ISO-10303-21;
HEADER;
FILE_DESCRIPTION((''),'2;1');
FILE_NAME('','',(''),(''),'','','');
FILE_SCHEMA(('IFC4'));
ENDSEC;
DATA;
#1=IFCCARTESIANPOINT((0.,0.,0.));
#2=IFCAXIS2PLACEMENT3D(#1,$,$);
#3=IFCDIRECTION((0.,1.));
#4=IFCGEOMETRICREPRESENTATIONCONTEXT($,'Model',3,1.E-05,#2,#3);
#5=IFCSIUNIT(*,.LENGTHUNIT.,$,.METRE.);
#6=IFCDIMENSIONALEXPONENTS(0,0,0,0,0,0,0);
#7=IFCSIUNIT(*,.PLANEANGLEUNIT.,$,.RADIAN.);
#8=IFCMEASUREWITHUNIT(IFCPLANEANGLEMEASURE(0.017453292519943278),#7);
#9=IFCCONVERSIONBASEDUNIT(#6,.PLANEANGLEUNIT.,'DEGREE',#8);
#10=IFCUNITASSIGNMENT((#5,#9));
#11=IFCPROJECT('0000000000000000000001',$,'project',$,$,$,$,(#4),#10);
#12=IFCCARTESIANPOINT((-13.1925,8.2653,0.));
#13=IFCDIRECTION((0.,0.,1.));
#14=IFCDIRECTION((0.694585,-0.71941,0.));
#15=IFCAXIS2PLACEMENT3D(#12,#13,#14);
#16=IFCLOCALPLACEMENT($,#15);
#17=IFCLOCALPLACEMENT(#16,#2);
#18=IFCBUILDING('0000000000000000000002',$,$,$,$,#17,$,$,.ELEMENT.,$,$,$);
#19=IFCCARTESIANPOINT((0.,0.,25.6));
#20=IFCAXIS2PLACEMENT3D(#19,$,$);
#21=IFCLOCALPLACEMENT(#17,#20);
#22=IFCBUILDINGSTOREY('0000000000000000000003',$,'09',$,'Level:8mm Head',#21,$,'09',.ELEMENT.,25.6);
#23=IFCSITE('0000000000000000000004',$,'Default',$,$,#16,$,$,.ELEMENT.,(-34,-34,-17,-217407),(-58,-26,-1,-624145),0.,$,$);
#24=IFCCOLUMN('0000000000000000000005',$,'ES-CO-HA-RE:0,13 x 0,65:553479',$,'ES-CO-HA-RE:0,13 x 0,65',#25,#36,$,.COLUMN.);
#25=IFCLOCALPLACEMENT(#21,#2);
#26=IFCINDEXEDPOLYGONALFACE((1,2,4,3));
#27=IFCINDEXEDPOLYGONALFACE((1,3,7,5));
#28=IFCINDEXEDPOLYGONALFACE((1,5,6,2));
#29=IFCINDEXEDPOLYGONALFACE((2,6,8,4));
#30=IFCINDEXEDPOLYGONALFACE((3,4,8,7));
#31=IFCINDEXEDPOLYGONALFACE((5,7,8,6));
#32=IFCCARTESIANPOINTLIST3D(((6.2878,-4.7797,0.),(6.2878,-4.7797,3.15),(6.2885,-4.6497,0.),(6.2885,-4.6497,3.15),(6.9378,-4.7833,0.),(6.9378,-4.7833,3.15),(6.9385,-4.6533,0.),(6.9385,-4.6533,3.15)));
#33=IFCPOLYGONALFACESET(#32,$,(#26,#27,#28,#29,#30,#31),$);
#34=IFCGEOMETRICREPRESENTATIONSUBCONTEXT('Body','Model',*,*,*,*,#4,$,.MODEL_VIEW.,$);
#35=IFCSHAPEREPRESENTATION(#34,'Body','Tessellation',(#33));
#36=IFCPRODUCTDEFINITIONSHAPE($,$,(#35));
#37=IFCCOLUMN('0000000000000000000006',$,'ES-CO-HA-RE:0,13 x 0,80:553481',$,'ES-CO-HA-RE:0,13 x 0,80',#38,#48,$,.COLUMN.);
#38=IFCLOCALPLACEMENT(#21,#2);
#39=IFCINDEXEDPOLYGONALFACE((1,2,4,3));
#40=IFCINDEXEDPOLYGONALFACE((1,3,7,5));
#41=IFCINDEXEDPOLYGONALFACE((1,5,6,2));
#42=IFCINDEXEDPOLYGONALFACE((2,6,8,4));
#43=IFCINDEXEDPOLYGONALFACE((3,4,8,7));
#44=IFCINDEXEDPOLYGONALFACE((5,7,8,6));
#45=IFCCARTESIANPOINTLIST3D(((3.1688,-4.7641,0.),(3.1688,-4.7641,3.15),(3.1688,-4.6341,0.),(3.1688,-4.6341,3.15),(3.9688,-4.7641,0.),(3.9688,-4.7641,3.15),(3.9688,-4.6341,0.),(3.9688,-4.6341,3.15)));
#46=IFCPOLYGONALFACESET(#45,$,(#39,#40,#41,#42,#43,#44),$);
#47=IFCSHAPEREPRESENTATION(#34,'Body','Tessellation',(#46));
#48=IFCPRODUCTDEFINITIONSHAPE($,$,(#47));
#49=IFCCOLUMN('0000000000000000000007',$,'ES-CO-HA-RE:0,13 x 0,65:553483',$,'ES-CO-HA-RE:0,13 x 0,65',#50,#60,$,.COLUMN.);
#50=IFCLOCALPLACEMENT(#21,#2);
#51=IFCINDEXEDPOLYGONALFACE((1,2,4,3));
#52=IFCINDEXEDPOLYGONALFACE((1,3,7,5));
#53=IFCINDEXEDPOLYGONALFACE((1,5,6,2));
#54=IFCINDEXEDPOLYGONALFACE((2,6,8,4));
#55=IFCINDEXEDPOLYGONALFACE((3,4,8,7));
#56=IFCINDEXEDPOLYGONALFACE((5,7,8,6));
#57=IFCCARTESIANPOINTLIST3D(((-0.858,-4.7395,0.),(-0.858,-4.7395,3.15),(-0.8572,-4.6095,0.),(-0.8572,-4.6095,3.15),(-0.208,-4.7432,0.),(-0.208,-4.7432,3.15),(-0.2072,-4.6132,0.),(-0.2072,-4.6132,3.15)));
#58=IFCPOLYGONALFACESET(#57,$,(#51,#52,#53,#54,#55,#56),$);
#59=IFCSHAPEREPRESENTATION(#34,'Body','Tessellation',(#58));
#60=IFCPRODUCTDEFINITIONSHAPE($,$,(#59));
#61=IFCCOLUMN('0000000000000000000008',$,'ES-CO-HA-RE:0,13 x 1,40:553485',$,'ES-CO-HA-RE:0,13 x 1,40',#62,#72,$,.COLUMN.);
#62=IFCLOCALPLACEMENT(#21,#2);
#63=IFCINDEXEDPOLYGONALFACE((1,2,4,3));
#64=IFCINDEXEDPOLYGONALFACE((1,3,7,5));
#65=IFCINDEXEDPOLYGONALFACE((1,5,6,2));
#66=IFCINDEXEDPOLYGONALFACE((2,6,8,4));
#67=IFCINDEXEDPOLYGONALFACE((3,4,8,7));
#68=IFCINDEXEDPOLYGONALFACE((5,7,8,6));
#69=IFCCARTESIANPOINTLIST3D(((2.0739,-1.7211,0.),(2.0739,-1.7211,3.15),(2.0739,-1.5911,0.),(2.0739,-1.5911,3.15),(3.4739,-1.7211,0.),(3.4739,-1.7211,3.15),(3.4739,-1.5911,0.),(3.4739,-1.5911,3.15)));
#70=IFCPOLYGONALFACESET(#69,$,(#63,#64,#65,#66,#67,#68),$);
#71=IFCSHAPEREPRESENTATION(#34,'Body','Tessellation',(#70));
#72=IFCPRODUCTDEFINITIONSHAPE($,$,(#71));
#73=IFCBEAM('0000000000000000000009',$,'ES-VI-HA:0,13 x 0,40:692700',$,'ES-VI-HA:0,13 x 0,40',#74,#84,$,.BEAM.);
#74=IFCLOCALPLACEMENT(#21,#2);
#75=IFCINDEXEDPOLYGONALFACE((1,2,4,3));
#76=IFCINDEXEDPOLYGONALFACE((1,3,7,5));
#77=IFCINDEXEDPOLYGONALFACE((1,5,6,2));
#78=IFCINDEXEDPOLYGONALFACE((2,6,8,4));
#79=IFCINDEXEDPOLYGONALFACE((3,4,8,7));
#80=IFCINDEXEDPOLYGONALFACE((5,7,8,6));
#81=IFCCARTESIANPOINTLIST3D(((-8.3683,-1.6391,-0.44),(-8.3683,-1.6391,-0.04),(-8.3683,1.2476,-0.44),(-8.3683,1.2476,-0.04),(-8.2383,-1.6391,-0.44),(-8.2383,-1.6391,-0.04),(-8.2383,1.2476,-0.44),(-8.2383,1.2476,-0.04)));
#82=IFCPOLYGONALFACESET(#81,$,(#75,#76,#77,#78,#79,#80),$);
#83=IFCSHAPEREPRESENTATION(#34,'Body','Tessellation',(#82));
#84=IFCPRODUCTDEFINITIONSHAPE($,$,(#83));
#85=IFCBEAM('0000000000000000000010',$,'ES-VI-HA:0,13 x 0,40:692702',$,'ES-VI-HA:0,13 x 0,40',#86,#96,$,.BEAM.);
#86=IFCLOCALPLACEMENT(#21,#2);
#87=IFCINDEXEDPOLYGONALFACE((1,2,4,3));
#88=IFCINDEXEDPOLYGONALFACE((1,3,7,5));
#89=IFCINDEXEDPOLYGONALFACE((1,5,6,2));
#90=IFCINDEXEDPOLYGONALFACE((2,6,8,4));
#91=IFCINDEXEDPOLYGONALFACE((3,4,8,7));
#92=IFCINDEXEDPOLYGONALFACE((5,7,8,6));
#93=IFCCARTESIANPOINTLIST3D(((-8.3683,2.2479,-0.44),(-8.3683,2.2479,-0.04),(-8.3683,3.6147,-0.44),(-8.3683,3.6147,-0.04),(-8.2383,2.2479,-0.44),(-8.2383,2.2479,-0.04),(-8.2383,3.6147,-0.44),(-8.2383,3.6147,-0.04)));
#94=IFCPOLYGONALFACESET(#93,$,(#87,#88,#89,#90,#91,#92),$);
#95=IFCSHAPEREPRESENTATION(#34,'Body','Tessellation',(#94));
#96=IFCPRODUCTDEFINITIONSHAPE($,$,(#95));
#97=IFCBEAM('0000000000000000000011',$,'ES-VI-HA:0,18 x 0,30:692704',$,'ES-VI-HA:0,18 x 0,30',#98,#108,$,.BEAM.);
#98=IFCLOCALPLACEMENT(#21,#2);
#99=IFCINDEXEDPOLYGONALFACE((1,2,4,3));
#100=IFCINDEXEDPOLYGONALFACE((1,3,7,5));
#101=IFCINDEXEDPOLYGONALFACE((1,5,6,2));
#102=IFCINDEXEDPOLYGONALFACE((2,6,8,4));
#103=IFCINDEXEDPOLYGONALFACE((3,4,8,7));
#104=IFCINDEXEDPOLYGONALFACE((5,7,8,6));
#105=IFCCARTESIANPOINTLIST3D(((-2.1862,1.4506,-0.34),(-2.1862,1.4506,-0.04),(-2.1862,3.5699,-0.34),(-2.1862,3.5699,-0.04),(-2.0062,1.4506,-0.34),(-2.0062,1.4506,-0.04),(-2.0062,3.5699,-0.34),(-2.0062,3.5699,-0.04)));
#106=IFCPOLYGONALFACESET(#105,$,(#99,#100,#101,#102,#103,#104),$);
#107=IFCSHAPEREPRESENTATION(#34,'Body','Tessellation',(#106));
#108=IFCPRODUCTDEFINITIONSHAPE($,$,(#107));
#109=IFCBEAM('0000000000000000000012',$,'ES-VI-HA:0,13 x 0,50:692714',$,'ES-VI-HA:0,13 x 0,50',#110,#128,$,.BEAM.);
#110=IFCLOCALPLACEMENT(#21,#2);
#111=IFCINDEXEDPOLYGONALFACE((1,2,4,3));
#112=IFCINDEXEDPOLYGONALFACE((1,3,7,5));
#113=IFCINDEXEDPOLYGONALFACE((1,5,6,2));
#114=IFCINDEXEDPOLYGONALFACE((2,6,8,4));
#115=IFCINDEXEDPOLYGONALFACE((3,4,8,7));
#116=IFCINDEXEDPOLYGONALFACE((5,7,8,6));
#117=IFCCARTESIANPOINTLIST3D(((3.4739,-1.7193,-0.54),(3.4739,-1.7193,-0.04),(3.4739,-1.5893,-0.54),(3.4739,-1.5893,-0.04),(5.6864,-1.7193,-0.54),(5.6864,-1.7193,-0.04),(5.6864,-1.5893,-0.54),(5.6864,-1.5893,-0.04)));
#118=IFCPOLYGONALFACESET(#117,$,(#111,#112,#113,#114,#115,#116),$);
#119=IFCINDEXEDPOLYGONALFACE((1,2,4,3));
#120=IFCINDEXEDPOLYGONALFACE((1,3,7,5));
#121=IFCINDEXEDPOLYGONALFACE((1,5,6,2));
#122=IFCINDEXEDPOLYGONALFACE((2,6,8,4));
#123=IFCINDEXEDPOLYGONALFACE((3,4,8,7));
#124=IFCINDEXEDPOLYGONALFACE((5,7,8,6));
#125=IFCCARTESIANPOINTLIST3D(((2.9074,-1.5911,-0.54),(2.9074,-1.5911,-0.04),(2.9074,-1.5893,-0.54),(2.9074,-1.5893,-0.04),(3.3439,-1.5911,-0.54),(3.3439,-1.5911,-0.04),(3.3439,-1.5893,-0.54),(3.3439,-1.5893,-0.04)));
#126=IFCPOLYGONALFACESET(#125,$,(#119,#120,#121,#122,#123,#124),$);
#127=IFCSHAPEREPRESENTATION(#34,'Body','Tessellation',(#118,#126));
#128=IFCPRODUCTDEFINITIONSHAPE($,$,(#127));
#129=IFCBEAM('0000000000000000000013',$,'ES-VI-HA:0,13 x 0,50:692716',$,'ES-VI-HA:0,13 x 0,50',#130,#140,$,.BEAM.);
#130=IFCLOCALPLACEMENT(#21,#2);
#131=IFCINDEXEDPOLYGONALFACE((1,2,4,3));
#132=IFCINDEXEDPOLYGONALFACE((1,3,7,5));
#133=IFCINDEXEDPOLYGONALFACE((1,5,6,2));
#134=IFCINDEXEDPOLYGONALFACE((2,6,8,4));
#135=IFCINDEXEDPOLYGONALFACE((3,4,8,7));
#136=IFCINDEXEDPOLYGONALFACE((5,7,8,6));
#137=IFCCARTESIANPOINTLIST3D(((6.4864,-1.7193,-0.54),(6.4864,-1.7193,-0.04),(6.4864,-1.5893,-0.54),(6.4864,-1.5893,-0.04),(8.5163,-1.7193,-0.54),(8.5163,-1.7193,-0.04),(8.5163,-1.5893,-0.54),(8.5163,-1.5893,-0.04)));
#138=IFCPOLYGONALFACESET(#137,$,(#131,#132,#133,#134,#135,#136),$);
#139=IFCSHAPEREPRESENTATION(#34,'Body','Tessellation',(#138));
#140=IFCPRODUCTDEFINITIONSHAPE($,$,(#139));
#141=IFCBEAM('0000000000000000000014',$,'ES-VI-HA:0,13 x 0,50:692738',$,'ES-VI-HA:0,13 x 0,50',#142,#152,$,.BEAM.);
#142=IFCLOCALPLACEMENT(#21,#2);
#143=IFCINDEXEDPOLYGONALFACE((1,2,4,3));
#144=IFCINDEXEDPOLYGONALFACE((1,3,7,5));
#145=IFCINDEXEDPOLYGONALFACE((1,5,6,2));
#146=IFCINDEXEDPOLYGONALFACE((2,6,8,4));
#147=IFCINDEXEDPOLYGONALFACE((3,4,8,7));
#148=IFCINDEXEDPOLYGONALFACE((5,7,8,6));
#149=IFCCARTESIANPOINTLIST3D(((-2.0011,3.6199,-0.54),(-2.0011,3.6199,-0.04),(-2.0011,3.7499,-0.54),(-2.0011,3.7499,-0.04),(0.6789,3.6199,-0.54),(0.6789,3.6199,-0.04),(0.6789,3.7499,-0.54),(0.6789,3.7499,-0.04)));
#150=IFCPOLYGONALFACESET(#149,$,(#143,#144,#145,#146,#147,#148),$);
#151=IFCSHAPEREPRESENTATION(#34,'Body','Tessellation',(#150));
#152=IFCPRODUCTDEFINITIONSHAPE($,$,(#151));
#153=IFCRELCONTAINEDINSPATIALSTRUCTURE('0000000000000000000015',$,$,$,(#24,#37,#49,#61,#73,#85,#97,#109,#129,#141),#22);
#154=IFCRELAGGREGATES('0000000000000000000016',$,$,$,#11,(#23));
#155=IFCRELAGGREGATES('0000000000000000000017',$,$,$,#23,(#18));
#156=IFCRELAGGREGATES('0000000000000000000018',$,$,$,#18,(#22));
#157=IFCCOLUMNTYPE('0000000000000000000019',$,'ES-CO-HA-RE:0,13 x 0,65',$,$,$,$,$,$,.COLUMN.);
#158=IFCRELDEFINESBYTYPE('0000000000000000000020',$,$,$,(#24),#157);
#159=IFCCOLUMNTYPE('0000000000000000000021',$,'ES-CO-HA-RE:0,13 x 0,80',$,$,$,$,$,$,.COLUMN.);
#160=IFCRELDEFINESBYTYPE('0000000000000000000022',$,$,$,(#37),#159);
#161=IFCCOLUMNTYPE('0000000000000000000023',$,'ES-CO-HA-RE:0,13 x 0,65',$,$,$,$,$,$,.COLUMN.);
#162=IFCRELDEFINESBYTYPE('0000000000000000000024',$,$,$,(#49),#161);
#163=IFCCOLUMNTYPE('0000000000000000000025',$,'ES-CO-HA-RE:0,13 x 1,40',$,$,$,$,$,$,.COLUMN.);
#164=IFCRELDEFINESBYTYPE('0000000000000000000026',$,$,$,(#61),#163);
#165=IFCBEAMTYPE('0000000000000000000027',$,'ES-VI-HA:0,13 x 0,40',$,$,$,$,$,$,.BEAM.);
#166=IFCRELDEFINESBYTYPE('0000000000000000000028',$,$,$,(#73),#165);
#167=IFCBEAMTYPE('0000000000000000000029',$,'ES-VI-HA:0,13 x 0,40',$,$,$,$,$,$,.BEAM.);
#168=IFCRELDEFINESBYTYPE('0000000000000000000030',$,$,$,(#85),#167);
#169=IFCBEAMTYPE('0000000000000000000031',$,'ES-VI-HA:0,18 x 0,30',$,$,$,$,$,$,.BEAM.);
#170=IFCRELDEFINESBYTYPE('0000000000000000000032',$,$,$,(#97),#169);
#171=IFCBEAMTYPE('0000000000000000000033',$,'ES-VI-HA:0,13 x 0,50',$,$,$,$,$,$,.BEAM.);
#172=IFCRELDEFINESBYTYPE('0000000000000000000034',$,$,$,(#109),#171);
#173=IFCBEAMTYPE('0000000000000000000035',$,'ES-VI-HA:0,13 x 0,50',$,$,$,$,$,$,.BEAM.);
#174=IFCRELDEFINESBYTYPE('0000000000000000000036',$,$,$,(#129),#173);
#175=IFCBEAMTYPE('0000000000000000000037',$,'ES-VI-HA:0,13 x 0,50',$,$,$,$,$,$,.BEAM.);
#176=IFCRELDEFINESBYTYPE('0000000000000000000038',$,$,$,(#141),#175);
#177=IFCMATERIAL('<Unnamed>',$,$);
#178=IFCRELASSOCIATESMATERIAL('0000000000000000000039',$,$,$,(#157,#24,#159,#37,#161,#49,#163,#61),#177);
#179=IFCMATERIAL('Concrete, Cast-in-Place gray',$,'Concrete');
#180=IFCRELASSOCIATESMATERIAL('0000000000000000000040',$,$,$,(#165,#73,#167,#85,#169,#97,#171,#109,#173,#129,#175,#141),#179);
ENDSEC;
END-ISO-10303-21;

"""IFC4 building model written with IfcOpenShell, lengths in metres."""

from ifc_helpers import new_model, entity, si_unit, converted_unit, direction, frame, origin, place, context, subcontext, project, spatial, indexed_curve, outline, extrude, source, transform, mapped, material, type_object, type_shapes, element, save


model = new_model("IFC4")

# Units and contexts
model_context = context("Model", 3, precision=1e-05, world=origin(), true_north=direction((0.0, 1.0)))
body_context = subcontext(model_context, "Body", "Model", "MODEL_VIEW")
ifc_project = project(units=[si_unit("LENGTHUNIT", "METRE"), converted_unit("PLANEANGLEUNIT", "DEGREE", entity("IfcPlaneAngleMeasure", 0.017453292519943278), si_unit("PLANEANGLEUNIT", "RADIAN"), dimensions=[0, 0, 0, 0, 0, 0, 0])], contexts=[model_context])

# Site, building, storey
site_placement = place(None, frame((-13.1925, 8.2653, 0.0), z_axis=(0.0, 0.0, 1.0), x_axis=(0.694585, -0.71941, 0.0)))
site = spatial("IfcSite", under=ifc_project, at=site_placement, Name="Default", CompositionType="ELEMENT", RefLatitude=(-34, -34, -17, -217407), RefLongitude=(-58, -26, -1, -624145), RefElevation=0.0)
building_placement = place(site_placement, origin())
building = spatial("IfcBuilding", under=site, at=building_placement, CompositionType="ELEMENT")
storey_placement = place(building_placement, frame((0.0, 0.0, 25.6)))
storey = spatial("IfcBuildingStorey", under=building, at=storey_placement, Name="09", ObjectType="Level:8mm Head", LongName="09", CompositionType="ELEMENT", Elevation=25.6)

# Columns
ifc_material_1 = material(Name="<Unnamed>")
column_type_1 = type_object("IfcColumnType", Name="ES-CO-HA-RE:0,13 x 0,65", PredefinedType="COLUMN", material=ifc_material_1)
shared_shape_1 = source(origin(), body_context, "Body", "SweptSolid", [
    extrude(outline(indexed_curve([(-0.325, -0.065), (0.325, -0.065), (0.325, 0.065), (-0.325, 0.065), (-0.325, -0.065)], self_intersect=False)), frame((6.6131, -4.7165, 25.6), z_axis=(0.0, 0.0, 1.0), x_axis=(-0.999984, 0.005619, 0.0)), (0.0, 0.0, 1.0), 3.15),
])
type_shapes(column_type_1, [shared_shape_1])
column_1_placement = place(storey_placement, frame((0.0, 0.0, -25.6)))
element("IfcColumn", 1, at=column_1_placement, inside=storey, type_object=column_type_1, material=ifc_material_1, Name="ES-CO-HA-RE:0,13 x 0,65:553479", ObjectType="ES-CO-HA-RE:0,13 x 0,65", PredefinedType="COLUMN", context=body_context, shape_type="MappedRepresentation", body=[
    mapped(shared_shape_1, transform((0.0, 0.0, 0.0), scale=1.0)),
])
column_type_2 = type_object("IfcColumnType", Name="ES-CO-HA-RE:0,13 x 0,80", PredefinedType="COLUMN", material=ifc_material_1)
shared_shape_2 = source(origin(), body_context, "Body", "SweptSolid", [
    extrude(outline(indexed_curve([(-0.4, -0.065), (0.4, -0.065), (0.4, 0.065), (-0.4, 0.065), (-0.4, -0.065)], self_intersect=False)), frame((3.5688, -4.6991, 25.6), z_axis=(0.0, 0.0, 1.0), x_axis=(-1.0, 0.0, 0.0)), (0.0, 0.0, 1.0), 3.15),
])
type_shapes(column_type_2, [shared_shape_2])
column_2_placement = place(storey_placement, frame((0.0, 0.0, -25.6)))
element("IfcColumn", 2, at=column_2_placement, inside=storey, type_object=column_type_2, material=ifc_material_1, Name="ES-CO-HA-RE:0,13 x 0,80:553481", ObjectType="ES-CO-HA-RE:0,13 x 0,80", PredefinedType="COLUMN", context=body_context, shape_type="MappedRepresentation", body=[
    mapped(shared_shape_2, transform((0.0, 0.0, 0.0), scale=1.0)),
])
column_type_3 = type_object("IfcColumnType", Name="ES-CO-HA-RE:0,13 x 0,65", PredefinedType="COLUMN", material=ifc_material_1)
shared_shape_3 = source(origin(), body_context, "Body", "SweptSolid", [
    extrude(outline(indexed_curve([(-0.325, -0.065), (0.325, -0.065), (0.325, 0.065), (-0.325, 0.065), (-0.325, -0.065)], self_intersect=False)), frame((-0.5326, -4.6764, 25.6), z_axis=(0.0, 0.0, 1.0), x_axis=(-0.999984, 0.005619, 0.0)), (0.0, 0.0, 1.0), 3.15),
])
type_shapes(column_type_3, [shared_shape_3])
column_3_placement = place(storey_placement, frame((0.0, 0.0, -25.6)))
element("IfcColumn", 3, at=column_3_placement, inside=storey, type_object=column_type_3, material=ifc_material_1, Name="ES-CO-HA-RE:0,13 x 0,65:553483", ObjectType="ES-CO-HA-RE:0,13 x 0,65", PredefinedType="COLUMN", context=body_context, shape_type="MappedRepresentation", body=[
    mapped(shared_shape_3, transform((0.0, 0.0, 0.0), scale=1.0)),
])
column_type_4 = type_object("IfcColumnType", Name="ES-CO-HA-RE:0,13 x 1,40", PredefinedType="COLUMN", material=ifc_material_1)
shared_shape_4 = source(origin(), body_context, "Body", "SweptSolid", [
    extrude(outline(indexed_curve([(-0.7, -0.065), (0.7, -0.065), (0.7, 0.065), (-0.7, 0.065), (-0.7, -0.065)], self_intersect=False)), frame((2.7739, -1.6561, 25.6), z_axis=(0.0, 0.0, 1.0), x_axis=(-1.0, 0.0, 0.0)), (0.0, 0.0, 1.0), 3.15),
])
type_shapes(column_type_4, [shared_shape_4])
column_4_placement = place(storey_placement, frame((0.0, 0.0, -25.6)))
element("IfcColumn", 4, at=column_4_placement, inside=storey, type_object=column_type_4, material=ifc_material_1, Name="ES-CO-HA-RE:0,13 x 1,40:553485", ObjectType="ES-CO-HA-RE:0,13 x 1,40", PredefinedType="COLUMN", context=body_context, shape_type="MappedRepresentation", body=[
    mapped(shared_shape_4, transform((0.0, 0.0, 0.0), scale=1.0)),
])

# Beams
ifc_material_2 = material(Name="Concrete, Cast-in-Place gray", Category="Concrete")
beam_type_1 = type_object("IfcBeamType", Name="ES-VI-HA:0,13 x 0,40", PredefinedType="BEAM", material=ifc_material_2)
shared_shape_5 = source(origin(), body_context, "Body", "SweptSolid", [
    extrude(outline(indexed_curve([(-0.065, -0.2), (0.065, -0.2), (0.065, 0.2), (-0.065, 0.2), (-0.065, -0.2)], self_intersect=False)), frame((-8.3033, -1.6391, 25.36), z_axis=(0.0, 1.0, 0.0), x_axis=(-1.0, 0.0, 0.0)), (0.0, 0.0, 1.0), 2.8867),
])
type_shapes(beam_type_1, [shared_shape_5])
beam_1_placement = place(storey_placement, frame((0.0, 0.0, -25.6)))
element("IfcBeam", 5, at=beam_1_placement, inside=storey, type_object=beam_type_1, material=ifc_material_2, Name="ES-VI-HA:0,13 x 0,40:692700", ObjectType="ES-VI-HA:0,13 x 0,40", PredefinedType="BEAM", context=body_context, shape_type="MappedRepresentation", body=[
    mapped(shared_shape_5, transform((0.0, 0.0, 0.0), scale=1.0)),
])
beam_type_2 = type_object("IfcBeamType", Name="ES-VI-HA:0,13 x 0,40", PredefinedType="BEAM", material=ifc_material_2)
shared_shape_6 = source(origin(), body_context, "Body", "SweptSolid", [
    extrude(outline(indexed_curve([(-0.065, -0.2), (0.065, -0.2), (0.065, 0.2), (-0.065, 0.2), (-0.065, -0.2)], self_intersect=False)), frame((-8.3033, 2.2479, 25.36), z_axis=(0.0, 1.0, 0.0), x_axis=(-1.0, 0.0, 0.0)), (0.0, 0.0, 1.0), 1.3668),
])
type_shapes(beam_type_2, [shared_shape_6])
beam_2_placement = place(storey_placement, frame((0.0, 0.0, -25.6)))
element("IfcBeam", 6, at=beam_2_placement, inside=storey, type_object=beam_type_2, material=ifc_material_2, Name="ES-VI-HA:0,13 x 0,40:692702", ObjectType="ES-VI-HA:0,13 x 0,40", PredefinedType="BEAM", context=body_context, shape_type="MappedRepresentation", body=[
    mapped(shared_shape_6, transform((0.0, 0.0, 0.0), scale=1.0)),
])
beam_type_3 = type_object("IfcBeamType", Name="ES-VI-HA:0,18 x 0,30", PredefinedType="BEAM", material=ifc_material_2)
shared_shape_7 = source(origin(), body_context, "Body", "SweptSolid", [
    extrude(outline(indexed_curve([(-0.09, -0.15), (0.09, -0.15), (0.09, 0.15), (-0.09, 0.15), (-0.09, -0.15)], self_intersect=False)), frame((-2.0962, 3.5699, 25.41), z_axis=(0.0, -1.0, 0.0), x_axis=(-1.0, 0.0, 0.0)), (0.0, 0.0, 1.0), 2.1193),
])
type_shapes(beam_type_3, [shared_shape_7])
beam_3_placement = place(storey_placement, frame((0.0, 0.0, -25.6)))
element("IfcBeam", 7, at=beam_3_placement, inside=storey, type_object=beam_type_3, material=ifc_material_2, Name="ES-VI-HA:0,18 x 0,30:692704", ObjectType="ES-VI-HA:0,18 x 0,30", PredefinedType="BEAM", context=body_context, shape_type="MappedRepresentation", body=[
    mapped(shared_shape_7, transform((0.0, 0.0, 0.0), scale=1.0)),
])
beam_type_4 = type_object("IfcBeamType", Name="ES-VI-HA:0,13 x 0,50", PredefinedType="BEAM", material=ifc_material_2)
shared_shape_8 = source(origin(), body_context, "Body", "SweptSolid", [
    extrude(outline(indexed_curve([(-0.25, -0.065), (0.25, -0.065), (0.25, 0.065), (-0.25, 0.065), (-0.25, -0.065)], self_intersect=False)), frame((3.4739, -1.6543, 25.31), z_axis=(1.0, 0.0, 0.0), x_axis=(0.0, 0.0, -1.0)), (0.0, 0.0, 1.0), 2.2125),
    extrude(outline(indexed_curve([(-0.25, -0.0009), (0.25, -0.0009), (0.25, 0.0009), (-0.25, 0.0009), (-0.25, -0.0009)], self_intersect=False)), frame((2.9074, -1.5902, 25.31), z_axis=(1.0, 0.0, 0.0), x_axis=(0.0, 0.0, -1.0)), (0.0, 0.0, 1.0), 0.4365),
])
type_shapes(beam_type_4, [shared_shape_8])
beam_4_placement = place(storey_placement, frame((0.0, 0.0, -25.6)))
element("IfcBeam", 8, at=beam_4_placement, inside=storey, type_object=beam_type_4, material=ifc_material_2, Name="ES-VI-HA:0,13 x 0,50:692714", ObjectType="ES-VI-HA:0,13 x 0,50", PredefinedType="BEAM", context=body_context, shape_type="MappedRepresentation", body=[
    mapped(shared_shape_8, transform((0.0, 0.0, 0.0), scale=1.0)),
])
beam_type_5 = type_object("IfcBeamType", Name="ES-VI-HA:0,13 x 0,50", PredefinedType="BEAM", material=ifc_material_2)
shared_shape_9 = source(origin(), body_context, "Body", "SweptSolid", [
    extrude(outline(indexed_curve([(-0.25, -0.065), (0.25, -0.065), (0.25, 0.065), (-0.25, 0.065), (-0.25, -0.065)], self_intersect=False)), frame((6.4864, -1.6543, 25.31), z_axis=(1.0, 0.0, 0.0), x_axis=(0.0, 0.0, -1.0)), (0.0, 0.0, 1.0), 2.0299),
])
type_shapes(beam_type_5, [shared_shape_9])
beam_5_placement = place(storey_placement, frame((0.0, 0.0, -25.6)))
element("IfcBeam", 9, at=beam_5_placement, inside=storey, type_object=beam_type_5, material=ifc_material_2, Name="ES-VI-HA:0,13 x 0,50:692716", ObjectType="ES-VI-HA:0,13 x 0,50", PredefinedType="BEAM", context=body_context, shape_type="MappedRepresentation", body=[
    mapped(shared_shape_9, transform((0.0, 0.0, 0.0), scale=1.0)),
])
beam_type_6 = type_object("IfcBeamType", Name="ES-VI-HA:0,13 x 0,50", PredefinedType="BEAM", material=ifc_material_2)
shared_shape_10 = source(origin(), body_context, "Body", "SweptSolid", [
    extrude(outline(indexed_curve([(-0.25, -0.065), (0.25, -0.065), (0.25, 0.065), (-0.25, 0.065), (-0.25, -0.065)], self_intersect=False)), frame((-2.0011, 3.6849, 25.31), z_axis=(1.0, 0.0, 0.0), x_axis=(0.0, 0.0, -1.0)), (0.0, 0.0, 1.0), 2.68),
])
type_shapes(beam_type_6, [shared_shape_10])
beam_6_placement = place(storey_placement, frame((0.0, 0.0, -25.6)))
element("IfcBeam", 10, at=beam_6_placement, inside=storey, type_object=beam_type_6, material=ifc_material_2, Name="ES-VI-HA:0,13 x 0,50:692738", ObjectType="ES-VI-HA:0,13 x 0,50", PredefinedType="BEAM", context=body_context, shape_type="MappedRepresentation", body=[
    mapped(shared_shape_10, transform((0.0, 0.0, 0.0), scale=1.0)),
])

save(model, "model.ifc")
